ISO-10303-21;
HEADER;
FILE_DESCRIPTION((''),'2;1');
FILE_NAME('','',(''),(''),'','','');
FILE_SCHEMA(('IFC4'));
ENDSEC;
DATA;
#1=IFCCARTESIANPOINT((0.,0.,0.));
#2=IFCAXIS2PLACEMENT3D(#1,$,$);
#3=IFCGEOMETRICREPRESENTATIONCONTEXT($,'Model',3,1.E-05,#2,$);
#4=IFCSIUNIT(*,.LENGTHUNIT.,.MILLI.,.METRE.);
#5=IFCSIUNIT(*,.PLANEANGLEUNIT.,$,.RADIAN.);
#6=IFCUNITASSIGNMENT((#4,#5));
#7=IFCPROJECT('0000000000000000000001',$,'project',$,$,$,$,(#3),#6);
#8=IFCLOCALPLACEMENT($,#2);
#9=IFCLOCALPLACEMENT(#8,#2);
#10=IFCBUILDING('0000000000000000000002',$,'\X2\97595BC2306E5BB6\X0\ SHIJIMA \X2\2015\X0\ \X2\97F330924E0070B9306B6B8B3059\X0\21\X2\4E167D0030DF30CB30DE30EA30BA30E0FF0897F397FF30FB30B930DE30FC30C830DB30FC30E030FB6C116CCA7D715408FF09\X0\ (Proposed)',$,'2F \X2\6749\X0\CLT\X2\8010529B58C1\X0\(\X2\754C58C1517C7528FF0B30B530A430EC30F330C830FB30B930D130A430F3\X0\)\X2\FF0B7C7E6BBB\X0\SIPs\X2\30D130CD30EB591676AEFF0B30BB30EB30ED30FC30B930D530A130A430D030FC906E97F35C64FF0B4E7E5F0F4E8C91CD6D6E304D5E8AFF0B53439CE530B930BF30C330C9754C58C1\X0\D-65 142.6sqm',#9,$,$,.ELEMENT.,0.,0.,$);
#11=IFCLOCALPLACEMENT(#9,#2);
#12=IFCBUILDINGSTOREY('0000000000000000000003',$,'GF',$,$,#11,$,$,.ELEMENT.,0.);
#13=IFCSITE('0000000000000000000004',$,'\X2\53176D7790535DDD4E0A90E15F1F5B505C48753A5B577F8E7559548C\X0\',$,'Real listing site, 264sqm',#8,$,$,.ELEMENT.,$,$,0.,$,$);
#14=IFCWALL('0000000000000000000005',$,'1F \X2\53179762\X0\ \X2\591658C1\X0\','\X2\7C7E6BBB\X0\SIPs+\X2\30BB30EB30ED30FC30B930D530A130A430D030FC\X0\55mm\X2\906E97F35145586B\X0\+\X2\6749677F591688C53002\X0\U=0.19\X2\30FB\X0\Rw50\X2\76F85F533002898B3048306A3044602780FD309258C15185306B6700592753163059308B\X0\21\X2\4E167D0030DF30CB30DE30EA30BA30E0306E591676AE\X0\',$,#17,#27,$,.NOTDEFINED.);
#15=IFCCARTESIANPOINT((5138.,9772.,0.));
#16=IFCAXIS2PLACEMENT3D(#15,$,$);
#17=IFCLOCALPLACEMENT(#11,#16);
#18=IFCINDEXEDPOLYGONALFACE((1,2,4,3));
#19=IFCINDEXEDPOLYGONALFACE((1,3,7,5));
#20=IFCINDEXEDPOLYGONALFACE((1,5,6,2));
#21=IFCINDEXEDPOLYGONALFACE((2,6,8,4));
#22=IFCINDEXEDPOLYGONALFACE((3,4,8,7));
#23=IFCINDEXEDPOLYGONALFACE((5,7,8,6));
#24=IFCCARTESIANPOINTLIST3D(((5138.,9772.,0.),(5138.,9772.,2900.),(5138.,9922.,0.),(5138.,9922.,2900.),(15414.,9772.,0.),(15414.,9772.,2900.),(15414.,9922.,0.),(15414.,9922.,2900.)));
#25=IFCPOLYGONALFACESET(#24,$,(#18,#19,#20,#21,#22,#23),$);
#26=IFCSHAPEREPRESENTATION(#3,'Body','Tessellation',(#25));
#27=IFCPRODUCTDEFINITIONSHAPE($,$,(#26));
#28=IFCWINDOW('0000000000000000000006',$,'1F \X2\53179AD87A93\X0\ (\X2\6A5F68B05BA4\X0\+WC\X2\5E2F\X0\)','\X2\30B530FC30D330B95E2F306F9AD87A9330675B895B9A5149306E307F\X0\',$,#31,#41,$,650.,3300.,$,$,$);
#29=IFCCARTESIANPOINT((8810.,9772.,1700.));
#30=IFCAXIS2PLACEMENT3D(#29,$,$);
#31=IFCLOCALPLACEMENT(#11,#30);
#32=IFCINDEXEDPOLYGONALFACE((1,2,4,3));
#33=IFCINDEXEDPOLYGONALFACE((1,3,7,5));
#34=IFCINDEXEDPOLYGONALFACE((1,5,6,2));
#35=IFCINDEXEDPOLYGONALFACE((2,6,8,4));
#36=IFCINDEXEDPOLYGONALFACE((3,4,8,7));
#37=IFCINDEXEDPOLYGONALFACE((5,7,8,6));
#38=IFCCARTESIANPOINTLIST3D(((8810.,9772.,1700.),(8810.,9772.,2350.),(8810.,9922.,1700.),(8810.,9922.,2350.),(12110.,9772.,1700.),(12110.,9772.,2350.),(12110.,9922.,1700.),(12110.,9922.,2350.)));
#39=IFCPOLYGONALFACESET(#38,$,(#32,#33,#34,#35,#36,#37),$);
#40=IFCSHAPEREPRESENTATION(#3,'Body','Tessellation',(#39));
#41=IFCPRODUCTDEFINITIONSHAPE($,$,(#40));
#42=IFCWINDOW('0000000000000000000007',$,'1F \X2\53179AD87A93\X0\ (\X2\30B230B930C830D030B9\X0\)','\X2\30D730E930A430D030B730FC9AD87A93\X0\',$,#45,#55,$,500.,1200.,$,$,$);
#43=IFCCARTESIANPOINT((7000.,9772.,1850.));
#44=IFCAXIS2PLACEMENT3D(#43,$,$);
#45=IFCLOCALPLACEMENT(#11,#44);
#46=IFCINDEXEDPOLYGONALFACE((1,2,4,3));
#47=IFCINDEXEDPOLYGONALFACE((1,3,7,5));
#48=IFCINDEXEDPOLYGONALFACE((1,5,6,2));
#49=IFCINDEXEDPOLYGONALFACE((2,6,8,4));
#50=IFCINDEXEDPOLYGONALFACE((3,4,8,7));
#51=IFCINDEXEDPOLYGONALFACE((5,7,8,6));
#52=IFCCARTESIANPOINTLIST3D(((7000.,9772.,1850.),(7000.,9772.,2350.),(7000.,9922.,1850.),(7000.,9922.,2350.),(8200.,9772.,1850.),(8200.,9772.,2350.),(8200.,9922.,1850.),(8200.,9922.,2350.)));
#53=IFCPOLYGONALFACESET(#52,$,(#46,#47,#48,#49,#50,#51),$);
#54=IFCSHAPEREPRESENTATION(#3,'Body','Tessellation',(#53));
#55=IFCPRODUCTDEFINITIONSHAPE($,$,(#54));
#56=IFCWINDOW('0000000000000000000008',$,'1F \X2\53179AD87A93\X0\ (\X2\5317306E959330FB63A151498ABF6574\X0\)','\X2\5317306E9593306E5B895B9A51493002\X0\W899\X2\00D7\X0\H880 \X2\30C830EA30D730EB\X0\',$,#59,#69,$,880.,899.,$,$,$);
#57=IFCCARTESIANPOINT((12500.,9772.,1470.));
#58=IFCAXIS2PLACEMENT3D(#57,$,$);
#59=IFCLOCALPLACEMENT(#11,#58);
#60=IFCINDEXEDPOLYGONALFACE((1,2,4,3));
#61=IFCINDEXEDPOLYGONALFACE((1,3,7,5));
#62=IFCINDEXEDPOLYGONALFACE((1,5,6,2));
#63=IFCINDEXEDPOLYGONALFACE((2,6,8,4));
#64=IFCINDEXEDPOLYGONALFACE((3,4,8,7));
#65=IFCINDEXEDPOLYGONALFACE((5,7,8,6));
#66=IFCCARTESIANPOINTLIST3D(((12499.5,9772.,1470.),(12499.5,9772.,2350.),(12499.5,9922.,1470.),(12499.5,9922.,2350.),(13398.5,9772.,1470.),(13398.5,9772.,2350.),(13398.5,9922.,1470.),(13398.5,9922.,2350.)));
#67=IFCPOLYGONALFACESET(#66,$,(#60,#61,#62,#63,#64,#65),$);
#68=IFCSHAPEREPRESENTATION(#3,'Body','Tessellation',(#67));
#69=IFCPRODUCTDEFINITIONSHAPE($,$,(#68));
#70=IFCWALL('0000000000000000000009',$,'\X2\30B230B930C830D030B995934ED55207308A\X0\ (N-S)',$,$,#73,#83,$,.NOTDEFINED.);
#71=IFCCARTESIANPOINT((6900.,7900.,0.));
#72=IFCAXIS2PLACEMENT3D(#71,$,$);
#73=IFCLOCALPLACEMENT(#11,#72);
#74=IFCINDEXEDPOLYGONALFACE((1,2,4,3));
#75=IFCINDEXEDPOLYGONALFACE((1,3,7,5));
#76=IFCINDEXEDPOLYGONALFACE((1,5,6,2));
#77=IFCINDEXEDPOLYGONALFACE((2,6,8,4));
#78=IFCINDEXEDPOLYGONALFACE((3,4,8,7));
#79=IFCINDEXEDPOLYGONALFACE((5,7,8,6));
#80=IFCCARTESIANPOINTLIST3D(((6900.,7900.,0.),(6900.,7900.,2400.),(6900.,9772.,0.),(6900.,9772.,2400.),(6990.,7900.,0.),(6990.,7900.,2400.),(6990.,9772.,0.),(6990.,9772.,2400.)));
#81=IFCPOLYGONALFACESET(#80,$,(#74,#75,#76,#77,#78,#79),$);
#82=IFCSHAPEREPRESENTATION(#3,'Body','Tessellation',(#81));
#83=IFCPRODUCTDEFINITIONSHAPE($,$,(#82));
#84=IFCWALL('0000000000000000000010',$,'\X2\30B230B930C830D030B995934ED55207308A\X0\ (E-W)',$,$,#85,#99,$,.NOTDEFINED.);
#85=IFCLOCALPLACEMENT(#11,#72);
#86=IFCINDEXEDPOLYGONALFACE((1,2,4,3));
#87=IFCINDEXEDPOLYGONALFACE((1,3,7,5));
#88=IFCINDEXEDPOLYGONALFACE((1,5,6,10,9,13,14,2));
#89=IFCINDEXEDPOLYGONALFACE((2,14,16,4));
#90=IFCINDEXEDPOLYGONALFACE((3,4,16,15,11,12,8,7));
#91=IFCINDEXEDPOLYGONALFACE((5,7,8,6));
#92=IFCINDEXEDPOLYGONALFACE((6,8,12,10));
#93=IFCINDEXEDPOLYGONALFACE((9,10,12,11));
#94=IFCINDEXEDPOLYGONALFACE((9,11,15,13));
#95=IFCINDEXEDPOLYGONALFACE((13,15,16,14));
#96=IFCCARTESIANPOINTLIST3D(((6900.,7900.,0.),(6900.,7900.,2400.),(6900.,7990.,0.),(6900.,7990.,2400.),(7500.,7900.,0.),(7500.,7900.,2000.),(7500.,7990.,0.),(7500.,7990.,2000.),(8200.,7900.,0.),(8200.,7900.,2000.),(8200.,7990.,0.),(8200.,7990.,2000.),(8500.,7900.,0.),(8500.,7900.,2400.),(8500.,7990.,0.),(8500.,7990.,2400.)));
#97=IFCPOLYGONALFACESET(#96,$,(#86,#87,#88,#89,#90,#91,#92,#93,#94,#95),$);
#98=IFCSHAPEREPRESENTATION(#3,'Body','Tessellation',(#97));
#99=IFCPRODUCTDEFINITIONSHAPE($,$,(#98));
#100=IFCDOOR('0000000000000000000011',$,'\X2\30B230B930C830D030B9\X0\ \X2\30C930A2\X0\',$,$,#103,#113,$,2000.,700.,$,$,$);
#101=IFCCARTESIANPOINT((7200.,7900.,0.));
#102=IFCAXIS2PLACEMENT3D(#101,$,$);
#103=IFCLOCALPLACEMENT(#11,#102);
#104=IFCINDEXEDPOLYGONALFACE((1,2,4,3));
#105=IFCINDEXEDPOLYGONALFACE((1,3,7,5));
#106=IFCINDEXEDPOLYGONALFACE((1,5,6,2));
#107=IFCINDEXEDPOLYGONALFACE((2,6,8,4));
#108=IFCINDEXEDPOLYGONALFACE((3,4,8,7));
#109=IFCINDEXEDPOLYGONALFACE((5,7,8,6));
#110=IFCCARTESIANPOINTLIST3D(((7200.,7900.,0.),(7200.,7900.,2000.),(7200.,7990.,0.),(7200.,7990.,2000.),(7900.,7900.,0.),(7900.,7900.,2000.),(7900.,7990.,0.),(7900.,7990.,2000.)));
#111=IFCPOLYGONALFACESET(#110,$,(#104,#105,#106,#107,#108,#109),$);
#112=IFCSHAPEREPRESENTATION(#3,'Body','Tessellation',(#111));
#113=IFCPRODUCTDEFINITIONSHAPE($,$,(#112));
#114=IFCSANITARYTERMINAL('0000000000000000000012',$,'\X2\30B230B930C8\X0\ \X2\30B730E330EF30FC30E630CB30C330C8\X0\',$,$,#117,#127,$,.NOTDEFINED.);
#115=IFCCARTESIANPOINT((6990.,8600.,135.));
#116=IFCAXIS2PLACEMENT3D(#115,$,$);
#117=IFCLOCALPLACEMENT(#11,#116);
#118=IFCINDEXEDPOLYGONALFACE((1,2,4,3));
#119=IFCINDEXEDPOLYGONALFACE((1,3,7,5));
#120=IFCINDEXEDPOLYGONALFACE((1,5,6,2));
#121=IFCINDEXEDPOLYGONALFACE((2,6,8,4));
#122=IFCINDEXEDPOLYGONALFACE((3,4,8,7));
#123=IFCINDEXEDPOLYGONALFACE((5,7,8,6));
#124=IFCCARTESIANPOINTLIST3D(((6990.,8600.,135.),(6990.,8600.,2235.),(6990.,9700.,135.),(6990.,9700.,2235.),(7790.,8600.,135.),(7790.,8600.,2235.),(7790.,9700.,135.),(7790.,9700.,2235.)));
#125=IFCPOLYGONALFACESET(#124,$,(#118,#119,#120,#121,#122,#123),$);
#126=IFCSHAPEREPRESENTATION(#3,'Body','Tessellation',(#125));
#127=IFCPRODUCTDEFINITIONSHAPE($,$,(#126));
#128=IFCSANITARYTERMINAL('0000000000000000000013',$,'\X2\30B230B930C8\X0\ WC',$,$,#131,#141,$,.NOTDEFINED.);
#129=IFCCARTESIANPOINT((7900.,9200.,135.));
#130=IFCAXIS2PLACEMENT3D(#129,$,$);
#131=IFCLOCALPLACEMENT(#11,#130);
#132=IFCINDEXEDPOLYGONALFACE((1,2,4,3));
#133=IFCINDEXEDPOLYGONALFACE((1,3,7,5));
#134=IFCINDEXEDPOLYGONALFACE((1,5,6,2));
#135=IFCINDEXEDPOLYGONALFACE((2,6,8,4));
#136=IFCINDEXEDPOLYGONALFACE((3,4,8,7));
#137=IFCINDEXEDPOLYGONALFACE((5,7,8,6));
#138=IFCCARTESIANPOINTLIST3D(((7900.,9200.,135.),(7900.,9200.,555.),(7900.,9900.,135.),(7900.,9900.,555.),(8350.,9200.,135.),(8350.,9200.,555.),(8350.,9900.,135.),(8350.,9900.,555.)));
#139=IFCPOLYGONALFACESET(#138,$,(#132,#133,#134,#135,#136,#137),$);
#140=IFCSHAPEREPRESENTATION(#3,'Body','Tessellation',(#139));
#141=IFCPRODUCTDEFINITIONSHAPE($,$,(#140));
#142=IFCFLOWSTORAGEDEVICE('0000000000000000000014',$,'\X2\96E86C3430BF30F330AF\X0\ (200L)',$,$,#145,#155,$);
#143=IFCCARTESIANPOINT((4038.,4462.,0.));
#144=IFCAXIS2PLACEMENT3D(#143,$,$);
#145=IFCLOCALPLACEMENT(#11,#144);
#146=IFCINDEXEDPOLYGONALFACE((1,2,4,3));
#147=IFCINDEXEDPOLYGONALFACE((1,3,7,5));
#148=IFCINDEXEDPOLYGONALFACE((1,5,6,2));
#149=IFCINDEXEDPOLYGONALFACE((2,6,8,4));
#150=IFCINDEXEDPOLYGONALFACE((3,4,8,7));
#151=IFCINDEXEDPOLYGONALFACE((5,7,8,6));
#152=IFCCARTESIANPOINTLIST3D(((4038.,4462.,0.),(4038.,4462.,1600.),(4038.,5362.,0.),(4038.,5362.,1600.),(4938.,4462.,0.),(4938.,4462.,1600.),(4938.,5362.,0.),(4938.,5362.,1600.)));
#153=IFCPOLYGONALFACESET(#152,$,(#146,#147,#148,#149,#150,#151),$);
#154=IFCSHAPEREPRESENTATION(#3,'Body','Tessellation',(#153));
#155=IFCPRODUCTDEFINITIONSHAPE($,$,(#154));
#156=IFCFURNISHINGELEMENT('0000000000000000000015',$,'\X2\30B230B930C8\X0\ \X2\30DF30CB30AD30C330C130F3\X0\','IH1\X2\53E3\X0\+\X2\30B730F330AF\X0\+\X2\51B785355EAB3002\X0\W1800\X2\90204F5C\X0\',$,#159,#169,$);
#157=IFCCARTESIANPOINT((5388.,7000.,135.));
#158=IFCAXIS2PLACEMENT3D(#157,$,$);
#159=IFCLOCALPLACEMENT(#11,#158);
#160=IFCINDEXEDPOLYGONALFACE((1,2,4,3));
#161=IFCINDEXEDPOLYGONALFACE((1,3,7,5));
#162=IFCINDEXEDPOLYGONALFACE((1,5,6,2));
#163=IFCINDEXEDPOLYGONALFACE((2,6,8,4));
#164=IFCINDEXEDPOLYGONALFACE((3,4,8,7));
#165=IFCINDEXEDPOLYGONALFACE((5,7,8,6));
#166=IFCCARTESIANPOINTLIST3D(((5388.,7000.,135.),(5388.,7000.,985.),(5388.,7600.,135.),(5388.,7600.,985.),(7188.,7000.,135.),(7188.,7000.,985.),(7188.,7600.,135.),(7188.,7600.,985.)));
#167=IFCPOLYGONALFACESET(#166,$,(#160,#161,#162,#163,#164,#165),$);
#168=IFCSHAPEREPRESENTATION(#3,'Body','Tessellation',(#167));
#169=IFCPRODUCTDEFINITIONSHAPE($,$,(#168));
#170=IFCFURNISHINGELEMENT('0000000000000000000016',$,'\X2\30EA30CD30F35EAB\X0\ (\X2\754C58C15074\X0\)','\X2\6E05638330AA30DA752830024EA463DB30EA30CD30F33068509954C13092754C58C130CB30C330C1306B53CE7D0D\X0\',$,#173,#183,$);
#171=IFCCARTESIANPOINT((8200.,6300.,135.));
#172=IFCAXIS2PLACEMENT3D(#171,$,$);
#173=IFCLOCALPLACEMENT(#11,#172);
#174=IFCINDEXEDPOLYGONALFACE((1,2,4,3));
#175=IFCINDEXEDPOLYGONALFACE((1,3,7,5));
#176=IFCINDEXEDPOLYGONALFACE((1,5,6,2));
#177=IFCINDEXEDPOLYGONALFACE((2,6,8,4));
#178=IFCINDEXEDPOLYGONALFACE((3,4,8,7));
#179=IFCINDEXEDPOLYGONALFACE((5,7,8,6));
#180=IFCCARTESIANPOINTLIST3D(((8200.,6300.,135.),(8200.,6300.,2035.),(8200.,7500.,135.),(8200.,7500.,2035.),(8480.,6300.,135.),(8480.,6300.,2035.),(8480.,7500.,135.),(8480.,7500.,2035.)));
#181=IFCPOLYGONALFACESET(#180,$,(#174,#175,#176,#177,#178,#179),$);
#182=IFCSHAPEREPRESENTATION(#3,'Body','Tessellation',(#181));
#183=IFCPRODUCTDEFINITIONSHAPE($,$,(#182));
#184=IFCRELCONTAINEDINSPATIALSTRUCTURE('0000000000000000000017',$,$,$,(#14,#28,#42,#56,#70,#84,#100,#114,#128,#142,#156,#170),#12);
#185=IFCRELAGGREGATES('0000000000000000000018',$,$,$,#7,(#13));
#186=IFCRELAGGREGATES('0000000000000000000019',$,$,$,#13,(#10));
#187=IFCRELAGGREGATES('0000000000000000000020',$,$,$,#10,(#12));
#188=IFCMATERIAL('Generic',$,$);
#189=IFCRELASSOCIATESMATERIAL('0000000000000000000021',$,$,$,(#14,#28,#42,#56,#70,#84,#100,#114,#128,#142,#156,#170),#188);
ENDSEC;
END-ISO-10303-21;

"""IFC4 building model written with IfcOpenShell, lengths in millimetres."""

from ifc_helpers import new_model, si_unit, frame, frame_2d, origin, place, context, project, spatial, rectangle, extrude, material, element, fill, save


model = new_model("IFC4")

# Units and contexts
model_context = context("Model", 3, precision=1e-05, world=origin())
ifc_project = project(units=[si_unit("LENGTHUNIT", "METRE", prefix="MILLI"), si_unit("PLANEANGLEUNIT", "RADIAN")], contexts=[model_context])

# Site, building, storey
site_placement = place(None, origin())
site = spatial("IfcSite", under=ifc_project, at=site_placement, Name="北海道川上郡弟子屈町字美留和", ObjectType="Real listing site, 264sqm", CompositionType="ELEMENT", RefElevation=0.0)
building_placement = place(site_placement, origin())
building = spatial("IfcBuilding", under=site, at=building_placement, Name="静寂の家 SHIJIMA ― 音を一点に残す21世紀ミニマリズム（音響・スマートホーム・民泊統合） (Proposed)", ObjectType="2F 杉CLT耐力壁(界壁兼用＋サイレント・スパイン)＋籾殻SIPsパネル外皮＋セルロースファイバー遮音層＋乾式二重浮き床＋千鳥スタッド界壁D-65 142.6sqm", CompositionType="ELEMENT", ElevationOfRefHeight=0.0, ElevationOfTerrain=0.0)
storey_placement = place(building_placement, origin())
storey = spatial("IfcBuildingStorey", under=building, at=storey_placement, Name="GF", CompositionType="ELEMENT", Elevation=0.0)

# Shared definitions
ifc_material = material(Name="Generic")

# Wall, openings, windows
wall_1_placement = place(storey_placement, frame((5138.0, 9772.0, 0.0)))
wall_1 = element("IfcWall", 1, at=wall_1_placement, inside=storey, material=ifc_material, Name="1F 北面 外壁", Description="籾殻SIPs+セルロースファイバー55mm遮音充填+杉板外装。U=0.19・Rw50相当。見えない性能を壁内に最大化する21世紀ミニマリズムの外皮", PredefinedType="NOTDEFINED", context=model_context, shape_type="SweptSolid", body=[
    extrude(rectangle(XDim=10276.0, YDim=150.0, at=frame_2d((5138.0, 75.0))), frame((5138.0, 9772.0, 0.0)), (0.0, 0.0, 1.0), 2900.0),
])
opening_1_placement = place(storey_placement, frame((8810.0, 9772.0, 1700.0)))
opening_1 = element("IfcOpeningElement", 2, at=opening_1_placement, cuts=wall_1, PredefinedType="NOTDEFINED", context=model_context, shape_type="SweptSolid", body=[
    extrude(rectangle(XDim=3300.0, YDim=150.0, at=frame_2d((1650.0, 75.0))), frame((8810.0, 9772.0, 1700.0)), (0.0, 0.0, 1.0), 650.0),
])
opening_2_placement = place(storey_placement, frame((7000.0, 9772.0, 1850.0)))
opening_2 = element("IfcOpeningElement", 3, at=opening_2_placement, cuts=wall_1, PredefinedType="NOTDEFINED", context=model_context, shape_type="SweptSolid", body=[
    extrude(rectangle(XDim=1200.0, YDim=150.0, at=frame_2d((600.0, 75.0))), frame((7000.0, 9772.0, 1850.0)), (0.0, 0.0, 1.0), 500.0),
])
opening_3_placement = place(storey_placement, frame((12500.0, 9772.0, 1470.0)))
opening_3 = element("IfcOpeningElement", 4, at=opening_3_placement, cuts=wall_1, PredefinedType="NOTDEFINED", context=model_context, shape_type="SweptSolid", body=[
    extrude(rectangle(XDim=899.0, YDim=150.0, at=frame_2d((449.0, 75.0))), frame((12500.0, 9772.0, 1470.0)), (0.0, 0.0, 1.0), 880.0),
])
window_1_placement = place(storey_placement, frame((8810.0, 9772.0, 1700.0)))
window_1 = element("IfcWindow", 5, at=window_1_placement, inside=storey, material=ifc_material, Name="1F 北高窓 (機械室+WC帯)", Description="サービス帯は高窓で安定光のみ", OverallHeight=650.0, OverallWidth=3300.0, context=model_context, shape_type="SweptSolid", body=[
    extrude(rectangle(XDim=3300.0, YDim=150.0, at=frame_2d((1650.0, 75.0))), frame((8810.0, 9772.0, 1700.0)), (0.0, 0.0, 1.0), 650.0),
])
fill(opening_1, window_1)
window_2_placement = place(storey_placement, frame((7000.0, 9772.0, 1850.0)))
window_2 = element("IfcWindow", 6, at=window_2_placement, inside=storey, material=ifc_material, Name="1F 北高窓 (ゲストバス)", Description="プライバシー高窓", OverallHeight=500.0, OverallWidth=1200.0, context=model_context, shape_type="SweptSolid", body=[
    extrude(rectangle(XDim=1200.0, YDim=150.0, at=frame_2d((600.0, 75.0))), frame((7000.0, 9772.0, 1850.0)), (0.0, 0.0, 1.0), 500.0),
])
fill(opening_2, window_2)
window_3_placement = place(storey_placement, frame((12500.0, 9772.0, 1470.0)))
window_3 = element("IfcWindow", 7, at=window_3_placement, inside=storey, material=ifc_material, Name="1F 北高窓 (北の間・採光調整)", Description="北の間の安定光。W899×H880 トリプル", OverallHeight=880.0, OverallWidth=899.0, context=model_context, shape_type="SweptSolid", body=[
    extrude(rectangle(XDim=899.0, YDim=150.0, at=frame_2d((449.0, 75.0))), frame((12500.0, 9772.0, 1470.0)), (0.0, 0.0, 1.0), 880.0),
])
fill(opening_3, window_3)

# Wall
wall_2_placement = place(storey_placement, frame((6900.0, 7900.0, 0.0)))
element("IfcWall", 8, at=wall_2_placement, inside=storey, material=ifc_material, Name="ゲストバス間仕切り (N-S)", PredefinedType="NOTDEFINED", context=model_context, shape_type="SweptSolid", body=[
    extrude(rectangle(XDim=90.0, YDim=1872.0, at=frame_2d((45.0, 936.0))), frame((6900.0, 7900.0, 0.0)), (0.0, 0.0, 1.0), 2400.0),
])

# Wall, opening, door
wall_3_placement = place(storey_placement, frame((6900.0, 7900.0, 0.0)))
wall_3 = element("IfcWall", 9, at=wall_3_placement, inside=storey, material=ifc_material, Name="ゲストバス間仕切り (E-W)", PredefinedType="NOTDEFINED", context=model_context, shape_type="SweptSolid", body=[
    extrude(rectangle(XDim=1600.0, YDim=90.0, at=frame_2d((800.0, 45.0))), frame((6900.0, 7900.0, 0.0)), (0.0, 0.0, 1.0), 2400.0),
])
opening_4_placement = place(storey_placement, frame((7200.0, 7900.0, 0.0)))
opening_4 = element("IfcOpeningElement", 10, at=opening_4_placement, cuts=wall_3, PredefinedType="NOTDEFINED", context=model_context, shape_type="SweptSolid", body=[
    extrude(rectangle(XDim=700.0, YDim=90.0, at=frame_2d((350.0, 45.0))), frame((7200.0, 7900.0, 0.0)), (0.0, 0.0, 1.0), 2000.0),
])
door_1_placement = place(storey_placement, frame((7200.0, 7900.0, 0.0)))
door_1 = element("IfcDoor", 11, at=door_1_placement, inside=storey, material=ifc_material, Name="ゲストバス ドア", OverallHeight=2000.0, OverallWidth=700.0, context=model_context, shape_type="SweptSolid", body=[
    extrude(rectangle(XDim=700.0, YDim=90.0, at=frame_2d((350.0, 45.0))), frame((7200.0, 7900.0, 0.0)), (0.0, 0.0, 1.0), 2000.0),
])
fill(opening_4, door_1)

# Sanitary terminals
sanitary_terminal_1_placement = place(storey_placement, frame((6990.0, 8600.0, 135.0)))
element("IfcSanitaryTerminal", 12, at=sanitary_terminal_1_placement, inside=storey, material=ifc_material, Name="ゲスト シャワーユニット", PredefinedType="NOTDEFINED", context=model_context, shape_type="SweptSolid", body=[
    extrude(rectangle(XDim=800.0, YDim=1100.0, at=frame_2d((400.0, 550.0))), frame((6990.0, 8600.0, 135.0)), (0.0, 0.0, 1.0), 2100.0),
])
sanitary_terminal_2_placement = place(storey_placement, frame((7900.0, 9200.0, 135.0)))
element("IfcSanitaryTerminal", 13, at=sanitary_terminal_2_placement, inside=storey, material=ifc_material, Name="ゲスト WC", PredefinedType="NOTDEFINED", context=model_context, shape_type="SweptSolid", body=[
    extrude(rectangle(XDim=450.0, YDim=700.0, at=frame_2d((225.0, 350.0))), frame((7900.0, 9200.0, 135.0)), (0.0, 0.0, 1.0), 420.0),
])

# Flow storage device
flow_storage_device_placement = place(storey_placement, frame((4038.0, 4462.0, 0.0)))
element("IfcFlowStorageDevice", 14, at=flow_storage_device_placement, inside=storey, material=ifc_material, Name="雨水タンク (200L)", context=model_context, shape_type="SweptSolid", body=[
    extrude(rectangle(XDim=900.0, YDim=900.0, at=frame_2d((450.0, 450.0))), frame((4038.0, 4462.0, 0.0)), (0.0, 0.0, 1.0), 1600.0),
])

# Furnishing elements
furnishing_1_placement = place(storey_placement, frame((5388.0, 7000.0, 135.0)))
element("IfcFurnishingElement", 15, at=furnishing_1_placement, inside=storey, material=ifc_material, Name="ゲスト ミニキッチン", Description="IH1口+シンク+冷蔵庫。W1800造作", context=model_context, shape_type="SweptSolid", body=[
    extrude(rectangle(XDim=1800.0, YDim=600.0, at=frame_2d((900.0, 300.0))), frame((5388.0, 7000.0, 135.0)), (0.0, 0.0, 1.0), 850.0),
])
furnishing_2_placement = place(storey_placement, frame((8200.0, 6300.0, 135.0)))
element("IfcFurnishingElement", 16, at=furnishing_2_placement, inside=storey, material=ifc_material, Name="リネン庫 (界壁側)", Description="清掃オペ用。交換リネンと備品を界壁ニッチに収納", context=model_context, shape_type="SweptSolid", body=[
    extrude(rectangle(XDim=280.0, YDim=1200.0, at=frame_2d((140.0, 600.0))), frame((8200.0, 6300.0, 135.0)), (0.0, 0.0, 1.0), 1900.0),
])

save(model, "model.ifc")
